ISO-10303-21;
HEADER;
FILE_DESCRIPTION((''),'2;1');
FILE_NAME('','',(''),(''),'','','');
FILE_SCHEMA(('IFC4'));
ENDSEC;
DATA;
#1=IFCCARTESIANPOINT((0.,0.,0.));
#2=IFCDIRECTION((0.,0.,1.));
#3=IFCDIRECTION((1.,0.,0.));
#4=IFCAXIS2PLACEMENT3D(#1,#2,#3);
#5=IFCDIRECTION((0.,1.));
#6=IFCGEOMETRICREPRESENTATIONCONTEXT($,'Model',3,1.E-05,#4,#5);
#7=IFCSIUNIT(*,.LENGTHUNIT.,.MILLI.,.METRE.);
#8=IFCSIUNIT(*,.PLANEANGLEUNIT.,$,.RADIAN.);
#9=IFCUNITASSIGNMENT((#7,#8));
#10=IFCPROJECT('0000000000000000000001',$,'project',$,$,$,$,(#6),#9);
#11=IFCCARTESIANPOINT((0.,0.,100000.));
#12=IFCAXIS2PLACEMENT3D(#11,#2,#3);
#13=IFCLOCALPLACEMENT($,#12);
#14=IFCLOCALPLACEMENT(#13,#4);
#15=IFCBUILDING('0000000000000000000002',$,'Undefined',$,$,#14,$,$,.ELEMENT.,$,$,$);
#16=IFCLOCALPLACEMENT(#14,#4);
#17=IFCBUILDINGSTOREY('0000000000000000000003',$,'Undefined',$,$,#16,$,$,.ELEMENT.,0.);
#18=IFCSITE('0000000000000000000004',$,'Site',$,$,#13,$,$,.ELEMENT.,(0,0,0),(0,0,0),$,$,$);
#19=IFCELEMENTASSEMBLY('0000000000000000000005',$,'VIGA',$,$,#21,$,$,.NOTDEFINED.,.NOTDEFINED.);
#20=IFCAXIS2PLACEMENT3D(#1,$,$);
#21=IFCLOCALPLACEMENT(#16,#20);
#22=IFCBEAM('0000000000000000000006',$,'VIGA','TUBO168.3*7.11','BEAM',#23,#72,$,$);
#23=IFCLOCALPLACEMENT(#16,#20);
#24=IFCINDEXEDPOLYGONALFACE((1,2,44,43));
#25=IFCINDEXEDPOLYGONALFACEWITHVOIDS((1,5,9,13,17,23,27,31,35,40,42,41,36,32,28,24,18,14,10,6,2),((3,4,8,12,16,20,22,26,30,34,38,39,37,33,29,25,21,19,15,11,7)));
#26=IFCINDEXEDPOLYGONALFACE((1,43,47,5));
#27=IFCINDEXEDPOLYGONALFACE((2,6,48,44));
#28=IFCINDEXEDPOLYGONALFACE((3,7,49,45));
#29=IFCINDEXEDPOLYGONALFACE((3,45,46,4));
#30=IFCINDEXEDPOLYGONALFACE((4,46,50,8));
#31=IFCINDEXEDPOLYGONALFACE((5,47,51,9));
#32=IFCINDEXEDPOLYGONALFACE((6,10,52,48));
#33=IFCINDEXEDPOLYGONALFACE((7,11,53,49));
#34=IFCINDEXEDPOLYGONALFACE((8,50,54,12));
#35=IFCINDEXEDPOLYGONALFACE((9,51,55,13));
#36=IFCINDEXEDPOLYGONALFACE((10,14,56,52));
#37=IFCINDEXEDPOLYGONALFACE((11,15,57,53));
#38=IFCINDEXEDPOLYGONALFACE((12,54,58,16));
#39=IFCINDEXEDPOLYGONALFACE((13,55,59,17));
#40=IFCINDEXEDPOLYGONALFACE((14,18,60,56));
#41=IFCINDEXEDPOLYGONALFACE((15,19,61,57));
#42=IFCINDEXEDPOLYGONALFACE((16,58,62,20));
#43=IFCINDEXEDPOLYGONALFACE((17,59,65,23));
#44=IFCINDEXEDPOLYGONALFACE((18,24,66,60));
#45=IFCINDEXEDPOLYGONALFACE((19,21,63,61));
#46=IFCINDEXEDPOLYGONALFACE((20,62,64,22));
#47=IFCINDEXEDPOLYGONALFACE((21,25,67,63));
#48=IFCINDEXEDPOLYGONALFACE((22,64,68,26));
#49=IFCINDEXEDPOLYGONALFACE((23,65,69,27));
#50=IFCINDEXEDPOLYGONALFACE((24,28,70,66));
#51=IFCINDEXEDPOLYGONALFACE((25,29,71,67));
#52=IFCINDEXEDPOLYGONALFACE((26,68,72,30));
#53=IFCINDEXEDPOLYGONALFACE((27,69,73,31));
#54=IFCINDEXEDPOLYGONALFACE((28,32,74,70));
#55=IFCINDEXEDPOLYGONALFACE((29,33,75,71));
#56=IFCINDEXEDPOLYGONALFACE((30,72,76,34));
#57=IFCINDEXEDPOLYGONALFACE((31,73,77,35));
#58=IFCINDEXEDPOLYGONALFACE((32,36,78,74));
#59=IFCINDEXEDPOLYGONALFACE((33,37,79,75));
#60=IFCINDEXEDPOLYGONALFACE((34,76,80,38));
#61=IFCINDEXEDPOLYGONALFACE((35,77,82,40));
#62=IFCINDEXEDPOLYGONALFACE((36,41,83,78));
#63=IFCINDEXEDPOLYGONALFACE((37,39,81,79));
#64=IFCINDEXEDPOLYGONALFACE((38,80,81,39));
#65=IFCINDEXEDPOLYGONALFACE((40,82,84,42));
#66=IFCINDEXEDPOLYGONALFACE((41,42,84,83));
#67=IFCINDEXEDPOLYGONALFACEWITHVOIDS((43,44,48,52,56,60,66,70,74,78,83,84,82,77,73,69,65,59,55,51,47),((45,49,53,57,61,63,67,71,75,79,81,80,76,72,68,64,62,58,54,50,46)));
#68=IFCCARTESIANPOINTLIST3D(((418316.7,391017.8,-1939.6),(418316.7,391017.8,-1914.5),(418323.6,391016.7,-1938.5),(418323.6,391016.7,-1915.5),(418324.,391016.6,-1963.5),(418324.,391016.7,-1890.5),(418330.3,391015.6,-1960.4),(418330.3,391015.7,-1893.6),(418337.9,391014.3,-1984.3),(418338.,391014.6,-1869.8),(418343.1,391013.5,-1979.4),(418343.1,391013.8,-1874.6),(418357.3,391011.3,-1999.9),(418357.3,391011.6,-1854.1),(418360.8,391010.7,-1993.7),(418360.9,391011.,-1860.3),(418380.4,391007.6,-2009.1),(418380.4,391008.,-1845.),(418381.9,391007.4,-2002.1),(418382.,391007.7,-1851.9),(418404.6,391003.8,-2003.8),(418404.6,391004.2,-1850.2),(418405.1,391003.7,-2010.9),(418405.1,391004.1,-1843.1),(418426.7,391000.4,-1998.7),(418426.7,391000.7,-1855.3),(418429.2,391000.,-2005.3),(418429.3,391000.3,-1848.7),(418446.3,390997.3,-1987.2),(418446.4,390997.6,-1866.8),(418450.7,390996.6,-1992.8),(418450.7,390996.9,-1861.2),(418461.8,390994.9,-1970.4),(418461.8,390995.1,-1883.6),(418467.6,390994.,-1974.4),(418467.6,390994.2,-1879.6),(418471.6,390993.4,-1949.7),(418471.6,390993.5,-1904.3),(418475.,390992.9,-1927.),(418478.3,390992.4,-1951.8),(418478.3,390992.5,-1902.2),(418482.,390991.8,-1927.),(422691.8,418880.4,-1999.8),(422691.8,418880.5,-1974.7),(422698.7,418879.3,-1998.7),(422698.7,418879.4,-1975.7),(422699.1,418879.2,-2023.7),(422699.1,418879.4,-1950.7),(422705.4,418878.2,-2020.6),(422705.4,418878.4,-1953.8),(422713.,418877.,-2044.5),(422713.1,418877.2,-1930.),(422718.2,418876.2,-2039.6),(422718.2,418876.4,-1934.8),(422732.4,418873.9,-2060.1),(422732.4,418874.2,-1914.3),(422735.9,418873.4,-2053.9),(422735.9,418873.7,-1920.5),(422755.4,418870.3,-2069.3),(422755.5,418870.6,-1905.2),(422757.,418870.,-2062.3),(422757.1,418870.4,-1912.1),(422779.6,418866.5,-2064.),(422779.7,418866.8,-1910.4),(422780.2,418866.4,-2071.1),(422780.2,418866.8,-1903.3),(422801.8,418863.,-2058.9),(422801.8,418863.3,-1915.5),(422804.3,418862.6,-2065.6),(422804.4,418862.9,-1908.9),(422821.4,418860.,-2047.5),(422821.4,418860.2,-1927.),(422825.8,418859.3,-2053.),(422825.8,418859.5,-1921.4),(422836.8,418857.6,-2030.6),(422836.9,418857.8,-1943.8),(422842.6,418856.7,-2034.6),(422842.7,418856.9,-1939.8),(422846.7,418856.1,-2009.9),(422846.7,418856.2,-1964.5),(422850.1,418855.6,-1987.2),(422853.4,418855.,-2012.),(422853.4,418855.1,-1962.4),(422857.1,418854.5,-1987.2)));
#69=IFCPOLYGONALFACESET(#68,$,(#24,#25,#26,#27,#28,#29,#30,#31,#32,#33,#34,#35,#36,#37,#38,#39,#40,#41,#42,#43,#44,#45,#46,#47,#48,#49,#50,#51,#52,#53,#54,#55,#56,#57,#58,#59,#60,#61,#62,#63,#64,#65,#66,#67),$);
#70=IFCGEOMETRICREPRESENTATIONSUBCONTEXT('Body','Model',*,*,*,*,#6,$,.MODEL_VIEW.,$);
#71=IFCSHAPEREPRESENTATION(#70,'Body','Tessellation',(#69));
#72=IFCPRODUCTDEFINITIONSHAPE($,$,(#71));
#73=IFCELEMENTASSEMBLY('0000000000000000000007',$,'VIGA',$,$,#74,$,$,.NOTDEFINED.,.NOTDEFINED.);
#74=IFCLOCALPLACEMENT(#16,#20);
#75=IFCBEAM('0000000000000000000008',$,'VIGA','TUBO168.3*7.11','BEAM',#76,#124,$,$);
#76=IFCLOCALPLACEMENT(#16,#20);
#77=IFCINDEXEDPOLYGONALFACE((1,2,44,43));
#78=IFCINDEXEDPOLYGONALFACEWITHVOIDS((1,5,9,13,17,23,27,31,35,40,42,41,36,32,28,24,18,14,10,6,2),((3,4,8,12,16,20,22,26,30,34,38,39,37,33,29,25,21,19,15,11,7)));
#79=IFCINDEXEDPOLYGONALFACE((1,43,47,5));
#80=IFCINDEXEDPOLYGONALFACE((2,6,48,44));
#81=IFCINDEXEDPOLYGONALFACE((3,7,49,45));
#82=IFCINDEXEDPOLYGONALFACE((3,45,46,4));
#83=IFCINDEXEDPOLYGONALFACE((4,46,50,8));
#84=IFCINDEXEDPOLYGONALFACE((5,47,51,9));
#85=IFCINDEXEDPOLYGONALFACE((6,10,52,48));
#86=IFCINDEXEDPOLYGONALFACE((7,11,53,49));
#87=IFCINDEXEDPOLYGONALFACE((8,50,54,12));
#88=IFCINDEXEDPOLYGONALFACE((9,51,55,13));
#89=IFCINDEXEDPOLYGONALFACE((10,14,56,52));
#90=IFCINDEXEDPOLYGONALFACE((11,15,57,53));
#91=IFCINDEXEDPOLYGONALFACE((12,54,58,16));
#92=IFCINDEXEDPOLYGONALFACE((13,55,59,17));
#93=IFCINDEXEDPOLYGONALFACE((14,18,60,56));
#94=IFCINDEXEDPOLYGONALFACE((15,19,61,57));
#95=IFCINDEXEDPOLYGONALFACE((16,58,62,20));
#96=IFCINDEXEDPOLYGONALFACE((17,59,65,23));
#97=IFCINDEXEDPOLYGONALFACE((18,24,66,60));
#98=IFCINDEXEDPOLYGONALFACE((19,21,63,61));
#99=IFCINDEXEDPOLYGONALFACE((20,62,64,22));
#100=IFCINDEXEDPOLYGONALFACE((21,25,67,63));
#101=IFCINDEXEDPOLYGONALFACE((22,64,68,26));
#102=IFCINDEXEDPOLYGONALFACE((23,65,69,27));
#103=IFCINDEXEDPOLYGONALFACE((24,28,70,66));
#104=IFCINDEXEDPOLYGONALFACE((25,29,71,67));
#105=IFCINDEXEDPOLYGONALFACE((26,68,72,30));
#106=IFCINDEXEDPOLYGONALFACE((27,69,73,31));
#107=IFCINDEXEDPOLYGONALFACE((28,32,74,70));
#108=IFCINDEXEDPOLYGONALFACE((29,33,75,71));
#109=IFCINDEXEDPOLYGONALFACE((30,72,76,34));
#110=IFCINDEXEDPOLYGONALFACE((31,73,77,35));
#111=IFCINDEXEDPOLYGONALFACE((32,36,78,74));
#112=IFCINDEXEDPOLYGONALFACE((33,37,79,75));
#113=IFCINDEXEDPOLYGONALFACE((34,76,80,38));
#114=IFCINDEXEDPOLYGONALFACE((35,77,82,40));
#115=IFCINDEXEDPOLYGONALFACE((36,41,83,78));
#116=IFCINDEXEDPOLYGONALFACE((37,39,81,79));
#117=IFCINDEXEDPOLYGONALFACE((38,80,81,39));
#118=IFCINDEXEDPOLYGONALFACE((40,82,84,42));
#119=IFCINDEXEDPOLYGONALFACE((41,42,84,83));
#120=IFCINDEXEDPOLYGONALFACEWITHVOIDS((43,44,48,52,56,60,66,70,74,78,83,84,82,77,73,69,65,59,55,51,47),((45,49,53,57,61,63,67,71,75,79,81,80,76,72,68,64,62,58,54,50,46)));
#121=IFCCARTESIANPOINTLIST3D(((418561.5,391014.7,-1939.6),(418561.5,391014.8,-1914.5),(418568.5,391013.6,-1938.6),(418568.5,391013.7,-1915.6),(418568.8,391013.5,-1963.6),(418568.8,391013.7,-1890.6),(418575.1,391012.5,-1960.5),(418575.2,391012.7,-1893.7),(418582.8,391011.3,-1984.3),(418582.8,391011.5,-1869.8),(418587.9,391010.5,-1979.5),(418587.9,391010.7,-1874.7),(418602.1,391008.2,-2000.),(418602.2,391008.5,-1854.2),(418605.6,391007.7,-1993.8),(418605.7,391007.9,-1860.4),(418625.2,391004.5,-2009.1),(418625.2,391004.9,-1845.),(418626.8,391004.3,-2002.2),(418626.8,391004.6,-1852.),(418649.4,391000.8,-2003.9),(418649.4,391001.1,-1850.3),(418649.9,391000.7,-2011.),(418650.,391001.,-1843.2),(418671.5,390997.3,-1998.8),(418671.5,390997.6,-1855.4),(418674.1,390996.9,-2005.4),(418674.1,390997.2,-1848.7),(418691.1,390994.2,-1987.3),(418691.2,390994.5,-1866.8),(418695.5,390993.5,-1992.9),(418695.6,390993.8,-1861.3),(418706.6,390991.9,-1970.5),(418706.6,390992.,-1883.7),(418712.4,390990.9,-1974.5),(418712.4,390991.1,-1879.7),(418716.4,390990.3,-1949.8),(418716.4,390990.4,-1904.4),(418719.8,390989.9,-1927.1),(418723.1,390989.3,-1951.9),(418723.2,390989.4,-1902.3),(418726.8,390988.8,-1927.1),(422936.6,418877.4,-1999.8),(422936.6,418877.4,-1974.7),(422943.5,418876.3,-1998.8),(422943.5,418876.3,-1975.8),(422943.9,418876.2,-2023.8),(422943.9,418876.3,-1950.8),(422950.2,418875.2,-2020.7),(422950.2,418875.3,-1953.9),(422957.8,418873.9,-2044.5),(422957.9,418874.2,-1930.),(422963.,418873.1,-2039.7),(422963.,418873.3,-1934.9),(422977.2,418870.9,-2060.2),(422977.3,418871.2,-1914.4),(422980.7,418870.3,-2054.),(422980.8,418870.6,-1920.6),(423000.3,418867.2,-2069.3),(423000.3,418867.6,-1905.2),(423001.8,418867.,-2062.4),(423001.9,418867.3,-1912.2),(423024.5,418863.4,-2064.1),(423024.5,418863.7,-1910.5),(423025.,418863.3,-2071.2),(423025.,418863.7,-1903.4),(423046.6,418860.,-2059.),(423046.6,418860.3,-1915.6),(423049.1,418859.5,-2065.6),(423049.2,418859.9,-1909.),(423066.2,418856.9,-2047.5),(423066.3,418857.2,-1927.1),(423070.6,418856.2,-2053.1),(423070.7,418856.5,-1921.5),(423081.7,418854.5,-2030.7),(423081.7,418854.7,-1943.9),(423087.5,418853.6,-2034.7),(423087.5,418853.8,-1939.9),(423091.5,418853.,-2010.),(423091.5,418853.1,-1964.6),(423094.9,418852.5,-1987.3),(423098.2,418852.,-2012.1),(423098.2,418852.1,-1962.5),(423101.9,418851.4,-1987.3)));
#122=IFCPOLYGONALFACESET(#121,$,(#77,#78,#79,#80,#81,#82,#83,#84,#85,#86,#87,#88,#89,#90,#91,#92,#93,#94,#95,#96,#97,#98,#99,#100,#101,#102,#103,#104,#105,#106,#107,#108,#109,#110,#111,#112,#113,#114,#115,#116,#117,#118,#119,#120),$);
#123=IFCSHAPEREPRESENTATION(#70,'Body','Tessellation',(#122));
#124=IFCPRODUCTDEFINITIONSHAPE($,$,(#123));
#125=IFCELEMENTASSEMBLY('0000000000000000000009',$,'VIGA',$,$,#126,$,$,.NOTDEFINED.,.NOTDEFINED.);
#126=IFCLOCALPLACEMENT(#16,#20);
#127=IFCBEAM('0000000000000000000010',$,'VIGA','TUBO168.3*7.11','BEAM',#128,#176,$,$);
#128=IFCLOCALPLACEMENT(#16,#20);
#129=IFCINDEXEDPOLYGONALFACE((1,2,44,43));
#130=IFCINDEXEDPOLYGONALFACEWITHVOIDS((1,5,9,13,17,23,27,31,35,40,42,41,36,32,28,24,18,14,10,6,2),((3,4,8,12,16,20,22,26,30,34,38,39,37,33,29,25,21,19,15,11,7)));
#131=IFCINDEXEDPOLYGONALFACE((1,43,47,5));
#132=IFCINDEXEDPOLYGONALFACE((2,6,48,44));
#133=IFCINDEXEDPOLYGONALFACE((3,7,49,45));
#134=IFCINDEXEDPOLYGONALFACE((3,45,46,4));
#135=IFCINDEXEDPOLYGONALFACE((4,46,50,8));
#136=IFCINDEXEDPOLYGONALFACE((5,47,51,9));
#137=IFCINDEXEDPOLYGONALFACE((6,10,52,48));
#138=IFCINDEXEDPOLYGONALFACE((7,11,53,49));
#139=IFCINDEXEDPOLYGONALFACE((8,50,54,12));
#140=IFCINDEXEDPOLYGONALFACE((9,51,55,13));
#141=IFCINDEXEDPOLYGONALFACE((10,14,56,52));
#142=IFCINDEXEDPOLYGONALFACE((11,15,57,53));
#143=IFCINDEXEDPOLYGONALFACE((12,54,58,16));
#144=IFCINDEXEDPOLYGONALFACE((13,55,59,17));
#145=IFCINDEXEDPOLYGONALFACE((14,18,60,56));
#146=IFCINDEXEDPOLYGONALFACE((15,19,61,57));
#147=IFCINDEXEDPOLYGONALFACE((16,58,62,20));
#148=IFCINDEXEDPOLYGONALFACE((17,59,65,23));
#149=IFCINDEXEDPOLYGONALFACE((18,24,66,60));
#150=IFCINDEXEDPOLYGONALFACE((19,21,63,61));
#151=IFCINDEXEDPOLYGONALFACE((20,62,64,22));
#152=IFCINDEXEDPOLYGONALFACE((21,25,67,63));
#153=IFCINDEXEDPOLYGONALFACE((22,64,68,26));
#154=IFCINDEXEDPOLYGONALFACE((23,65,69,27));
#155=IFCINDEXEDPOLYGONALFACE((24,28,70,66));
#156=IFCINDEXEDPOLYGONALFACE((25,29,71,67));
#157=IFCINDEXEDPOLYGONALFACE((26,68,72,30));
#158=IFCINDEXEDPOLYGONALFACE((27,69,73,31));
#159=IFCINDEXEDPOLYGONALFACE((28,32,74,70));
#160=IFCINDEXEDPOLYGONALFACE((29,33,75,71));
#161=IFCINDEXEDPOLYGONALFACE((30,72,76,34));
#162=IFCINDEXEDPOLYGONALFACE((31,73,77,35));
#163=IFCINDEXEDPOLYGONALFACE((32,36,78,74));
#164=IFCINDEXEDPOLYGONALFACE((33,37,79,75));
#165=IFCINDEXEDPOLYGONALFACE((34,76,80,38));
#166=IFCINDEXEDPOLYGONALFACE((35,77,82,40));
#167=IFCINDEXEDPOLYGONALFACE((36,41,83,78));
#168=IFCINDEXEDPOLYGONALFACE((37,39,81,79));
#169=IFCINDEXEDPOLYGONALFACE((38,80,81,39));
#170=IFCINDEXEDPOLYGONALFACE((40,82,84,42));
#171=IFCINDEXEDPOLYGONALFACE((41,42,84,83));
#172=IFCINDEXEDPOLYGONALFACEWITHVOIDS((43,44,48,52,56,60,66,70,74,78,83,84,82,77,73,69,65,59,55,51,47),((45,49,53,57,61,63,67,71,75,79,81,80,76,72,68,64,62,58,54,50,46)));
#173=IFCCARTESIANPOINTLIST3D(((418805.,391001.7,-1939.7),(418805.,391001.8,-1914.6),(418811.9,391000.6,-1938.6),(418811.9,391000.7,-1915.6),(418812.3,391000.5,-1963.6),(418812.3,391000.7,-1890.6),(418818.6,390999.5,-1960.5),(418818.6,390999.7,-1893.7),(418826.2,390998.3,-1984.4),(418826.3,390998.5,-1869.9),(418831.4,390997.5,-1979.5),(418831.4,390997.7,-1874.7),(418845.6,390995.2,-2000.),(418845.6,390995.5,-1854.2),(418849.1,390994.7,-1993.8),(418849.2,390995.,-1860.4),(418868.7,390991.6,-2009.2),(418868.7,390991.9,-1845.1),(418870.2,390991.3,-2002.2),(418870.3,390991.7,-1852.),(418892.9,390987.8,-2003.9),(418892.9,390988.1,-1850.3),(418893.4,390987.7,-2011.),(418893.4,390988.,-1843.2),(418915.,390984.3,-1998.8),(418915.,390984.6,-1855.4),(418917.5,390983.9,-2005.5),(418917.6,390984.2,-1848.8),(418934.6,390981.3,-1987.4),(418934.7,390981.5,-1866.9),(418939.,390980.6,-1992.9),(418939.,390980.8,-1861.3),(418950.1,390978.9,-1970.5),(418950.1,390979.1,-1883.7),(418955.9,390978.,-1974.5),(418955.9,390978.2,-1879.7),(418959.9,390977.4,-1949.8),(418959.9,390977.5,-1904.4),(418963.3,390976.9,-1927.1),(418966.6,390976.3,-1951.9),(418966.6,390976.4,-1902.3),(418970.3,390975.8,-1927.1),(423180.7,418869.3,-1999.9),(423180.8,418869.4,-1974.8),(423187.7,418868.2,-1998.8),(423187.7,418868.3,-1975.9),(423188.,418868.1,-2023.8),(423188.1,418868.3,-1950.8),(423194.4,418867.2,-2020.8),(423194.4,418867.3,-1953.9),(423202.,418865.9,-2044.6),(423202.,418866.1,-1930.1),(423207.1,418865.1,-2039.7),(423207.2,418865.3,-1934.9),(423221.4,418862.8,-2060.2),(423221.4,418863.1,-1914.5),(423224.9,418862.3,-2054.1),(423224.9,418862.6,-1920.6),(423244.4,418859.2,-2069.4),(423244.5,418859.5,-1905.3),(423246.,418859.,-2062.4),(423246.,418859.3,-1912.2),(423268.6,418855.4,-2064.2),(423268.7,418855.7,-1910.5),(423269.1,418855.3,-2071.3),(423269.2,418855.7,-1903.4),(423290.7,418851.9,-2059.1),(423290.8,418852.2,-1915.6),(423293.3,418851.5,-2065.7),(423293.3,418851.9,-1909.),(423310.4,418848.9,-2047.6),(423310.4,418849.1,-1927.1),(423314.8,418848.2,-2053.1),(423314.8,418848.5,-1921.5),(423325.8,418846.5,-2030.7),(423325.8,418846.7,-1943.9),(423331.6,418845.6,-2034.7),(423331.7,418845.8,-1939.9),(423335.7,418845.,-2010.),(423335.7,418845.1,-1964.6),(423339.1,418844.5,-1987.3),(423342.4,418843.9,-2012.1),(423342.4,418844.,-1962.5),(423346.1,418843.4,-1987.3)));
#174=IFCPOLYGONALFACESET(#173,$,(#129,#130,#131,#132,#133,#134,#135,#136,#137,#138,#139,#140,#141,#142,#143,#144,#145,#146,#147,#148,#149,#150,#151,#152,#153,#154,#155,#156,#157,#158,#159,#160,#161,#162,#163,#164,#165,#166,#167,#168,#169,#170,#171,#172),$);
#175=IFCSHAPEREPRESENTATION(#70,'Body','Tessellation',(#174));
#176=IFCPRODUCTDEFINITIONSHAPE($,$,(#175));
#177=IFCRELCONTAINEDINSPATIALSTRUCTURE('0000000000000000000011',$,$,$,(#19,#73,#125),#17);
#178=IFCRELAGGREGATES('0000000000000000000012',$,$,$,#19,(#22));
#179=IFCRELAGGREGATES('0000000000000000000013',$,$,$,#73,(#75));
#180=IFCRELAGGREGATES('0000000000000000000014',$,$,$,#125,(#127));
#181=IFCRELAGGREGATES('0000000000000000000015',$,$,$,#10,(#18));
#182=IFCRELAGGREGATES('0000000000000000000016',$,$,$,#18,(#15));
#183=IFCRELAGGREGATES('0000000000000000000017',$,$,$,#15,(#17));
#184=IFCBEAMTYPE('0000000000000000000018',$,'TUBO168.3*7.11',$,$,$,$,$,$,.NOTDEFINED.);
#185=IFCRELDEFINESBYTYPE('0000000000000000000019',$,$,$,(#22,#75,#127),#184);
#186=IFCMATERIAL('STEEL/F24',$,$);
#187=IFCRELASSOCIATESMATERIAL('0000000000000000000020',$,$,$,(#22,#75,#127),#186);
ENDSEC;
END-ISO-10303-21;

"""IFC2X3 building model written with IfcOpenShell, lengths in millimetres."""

from ifc_helpers import new_model, si_unit, direction, frame, origin_with_axes, origin_2d_with_axis, place, context, subcontext, project, spatial, hollow_circle, extrude, material, type_object, element, aggregate, save


model = new_model("IFC2X3")

# Units and contexts
model_context = context("Model", 3, precision=1e-05, world=origin_with_axes(), true_north=direction((0.0, 1.0)))
body_context = subcontext(model_context, "Body", "Model", "MODEL_VIEW")
ifc_project = project(units=[si_unit("LENGTHUNIT", "METRE", prefix="MILLI"), si_unit("PLANEANGLEUNIT", "RADIAN")], contexts=[model_context])

# Site, building, storey
site_placement = place(None, frame((0.0, 0.0, 100000.0), z_axis=(0.0, 0.0, 1.0), x_axis=(1.0, 0.0, 0.0)))
site = spatial("IfcSite", under=ifc_project, at=site_placement, Name="Site", CompositionType="ELEMENT", RefLatitude=(0, 0, 0), RefLongitude=(0, 0, 0))
building_placement = place(site_placement, origin_with_axes())
building = spatial("IfcBuilding", under=site, at=building_placement, Name="Undefined", CompositionType="ELEMENT")
storey_placement = place(building_placement, origin_with_axes())
storey = spatial("IfcBuildingStorey", under=building, at=storey_placement, Name="Undefined", CompositionType="ELEMENT", Elevation=0.0)

# Element assemblies, beams
ifc_material_1 = material(Name="STEEL/F24")
beam_type_1 = type_object("IfcBeamType", Name="TUBO168.3*7.11", PredefinedType="NOTDEFINED")
assembly_1_placement = place(storey_placement, origin_with_axes())
assembly_1 = element("IfcElementAssembly", 1, at=assembly_1_placement, inside=storey, Name="VIGA", AssemblyPlace="NOTDEFINED", PredefinedType="NOTDEFINED")
beam_1_placement = place(assembly_1_placement, frame((418398.9, 391004.9, -1927.0), z_axis=(0.000331, 0.002109, 0.999998), x_axis=(0.155122, 0.987893, -0.002135)))
beam_1 = element("IfcBeam", 2, at=beam_1_placement, type_object=beam_type_1, material=ifc_material_1, Name="VIGA", Description="TUBO168.3*7.11", ObjectType="BEAM", context=body_context, shape_type="SweptSolid", body=[
    extrude(hollow_circle(Radius=84.2, WallThickness=7.1, at=origin_2d_with_axis()), frame((28204.1, 0.0, 0.0), z_axis=(-1.0, 0.0, 0.0), x_axis=(0.0, -1.0, 0.0)), (0.0, 0.0, 1.0), 28204.1),
])
aggregate(assembly_1, [beam_1])
assembly_2_placement = place(storey_placement, origin_with_axes())
assembly_2 = element("IfcElementAssembly", 3, at=assembly_2_placement, inside=storey, Name="VIGA", AssemblyPlace="NOTDEFINED", PredefinedType="NOTDEFINED")
beam_2_placement = place(assembly_2_placement, frame((418643.7, 391001.8, -1927.1), z_axis=(0.000331, 0.002109, 0.999998), x_axis=(0.155122, 0.987893, -0.002135)))
beam_2 = element("IfcBeam", 4, at=beam_2_placement, type_object=beam_type_1, material=ifc_material_1, Name="VIGA", Description="TUBO168.3*7.11", ObjectType="BEAM", context=body_context, shape_type="SweptSolid", body=[
    extrude(hollow_circle(Radius=84.2, WallThickness=7.1, at=origin_2d_with_axis()), frame((28204.1, 0.0, 0.0), z_axis=(-1.0, 0.0, 0.0), x_axis=(0.0, -1.0, 0.0)), (0.0, 0.0, 1.0), 28204.1),
])
aggregate(assembly_2, [beam_2])
assembly_3_placement = place(storey_placement, origin_with_axes())
assembly_3 = element("IfcElementAssembly", 5, at=assembly_3_placement, inside=storey, Name="VIGA", AssemblyPlace="NOTDEFINED", PredefinedType="NOTDEFINED")
beam_3_placement = place(assembly_3_placement, frame((418887.2, 390988.8, -1927.1), z_axis=(0.000331, 0.002109, 0.999998), x_axis=(0.155119, 0.987894, -0.002135)))
beam_3 = element("IfcBeam", 6, at=beam_3_placement, type_object=beam_type_1, material=ifc_material_1, Name="VIGA", Description="TUBO168.3*7.11", ObjectType="BEAM", context=body_context, shape_type="SweptSolid", body=[
    extrude(hollow_circle(Radius=84.2, WallThickness=7.1, at=origin_2d_with_axis()), frame((28209.1, 0.0, 0.0), z_axis=(-1.0, 0.0, 0.0), x_axis=(0.0, -1.0, 0.0)), (0.0, 0.0, 1.0), 28209.1),
])
aggregate(assembly_3, [beam_3])

save(model, "model.ifc")
